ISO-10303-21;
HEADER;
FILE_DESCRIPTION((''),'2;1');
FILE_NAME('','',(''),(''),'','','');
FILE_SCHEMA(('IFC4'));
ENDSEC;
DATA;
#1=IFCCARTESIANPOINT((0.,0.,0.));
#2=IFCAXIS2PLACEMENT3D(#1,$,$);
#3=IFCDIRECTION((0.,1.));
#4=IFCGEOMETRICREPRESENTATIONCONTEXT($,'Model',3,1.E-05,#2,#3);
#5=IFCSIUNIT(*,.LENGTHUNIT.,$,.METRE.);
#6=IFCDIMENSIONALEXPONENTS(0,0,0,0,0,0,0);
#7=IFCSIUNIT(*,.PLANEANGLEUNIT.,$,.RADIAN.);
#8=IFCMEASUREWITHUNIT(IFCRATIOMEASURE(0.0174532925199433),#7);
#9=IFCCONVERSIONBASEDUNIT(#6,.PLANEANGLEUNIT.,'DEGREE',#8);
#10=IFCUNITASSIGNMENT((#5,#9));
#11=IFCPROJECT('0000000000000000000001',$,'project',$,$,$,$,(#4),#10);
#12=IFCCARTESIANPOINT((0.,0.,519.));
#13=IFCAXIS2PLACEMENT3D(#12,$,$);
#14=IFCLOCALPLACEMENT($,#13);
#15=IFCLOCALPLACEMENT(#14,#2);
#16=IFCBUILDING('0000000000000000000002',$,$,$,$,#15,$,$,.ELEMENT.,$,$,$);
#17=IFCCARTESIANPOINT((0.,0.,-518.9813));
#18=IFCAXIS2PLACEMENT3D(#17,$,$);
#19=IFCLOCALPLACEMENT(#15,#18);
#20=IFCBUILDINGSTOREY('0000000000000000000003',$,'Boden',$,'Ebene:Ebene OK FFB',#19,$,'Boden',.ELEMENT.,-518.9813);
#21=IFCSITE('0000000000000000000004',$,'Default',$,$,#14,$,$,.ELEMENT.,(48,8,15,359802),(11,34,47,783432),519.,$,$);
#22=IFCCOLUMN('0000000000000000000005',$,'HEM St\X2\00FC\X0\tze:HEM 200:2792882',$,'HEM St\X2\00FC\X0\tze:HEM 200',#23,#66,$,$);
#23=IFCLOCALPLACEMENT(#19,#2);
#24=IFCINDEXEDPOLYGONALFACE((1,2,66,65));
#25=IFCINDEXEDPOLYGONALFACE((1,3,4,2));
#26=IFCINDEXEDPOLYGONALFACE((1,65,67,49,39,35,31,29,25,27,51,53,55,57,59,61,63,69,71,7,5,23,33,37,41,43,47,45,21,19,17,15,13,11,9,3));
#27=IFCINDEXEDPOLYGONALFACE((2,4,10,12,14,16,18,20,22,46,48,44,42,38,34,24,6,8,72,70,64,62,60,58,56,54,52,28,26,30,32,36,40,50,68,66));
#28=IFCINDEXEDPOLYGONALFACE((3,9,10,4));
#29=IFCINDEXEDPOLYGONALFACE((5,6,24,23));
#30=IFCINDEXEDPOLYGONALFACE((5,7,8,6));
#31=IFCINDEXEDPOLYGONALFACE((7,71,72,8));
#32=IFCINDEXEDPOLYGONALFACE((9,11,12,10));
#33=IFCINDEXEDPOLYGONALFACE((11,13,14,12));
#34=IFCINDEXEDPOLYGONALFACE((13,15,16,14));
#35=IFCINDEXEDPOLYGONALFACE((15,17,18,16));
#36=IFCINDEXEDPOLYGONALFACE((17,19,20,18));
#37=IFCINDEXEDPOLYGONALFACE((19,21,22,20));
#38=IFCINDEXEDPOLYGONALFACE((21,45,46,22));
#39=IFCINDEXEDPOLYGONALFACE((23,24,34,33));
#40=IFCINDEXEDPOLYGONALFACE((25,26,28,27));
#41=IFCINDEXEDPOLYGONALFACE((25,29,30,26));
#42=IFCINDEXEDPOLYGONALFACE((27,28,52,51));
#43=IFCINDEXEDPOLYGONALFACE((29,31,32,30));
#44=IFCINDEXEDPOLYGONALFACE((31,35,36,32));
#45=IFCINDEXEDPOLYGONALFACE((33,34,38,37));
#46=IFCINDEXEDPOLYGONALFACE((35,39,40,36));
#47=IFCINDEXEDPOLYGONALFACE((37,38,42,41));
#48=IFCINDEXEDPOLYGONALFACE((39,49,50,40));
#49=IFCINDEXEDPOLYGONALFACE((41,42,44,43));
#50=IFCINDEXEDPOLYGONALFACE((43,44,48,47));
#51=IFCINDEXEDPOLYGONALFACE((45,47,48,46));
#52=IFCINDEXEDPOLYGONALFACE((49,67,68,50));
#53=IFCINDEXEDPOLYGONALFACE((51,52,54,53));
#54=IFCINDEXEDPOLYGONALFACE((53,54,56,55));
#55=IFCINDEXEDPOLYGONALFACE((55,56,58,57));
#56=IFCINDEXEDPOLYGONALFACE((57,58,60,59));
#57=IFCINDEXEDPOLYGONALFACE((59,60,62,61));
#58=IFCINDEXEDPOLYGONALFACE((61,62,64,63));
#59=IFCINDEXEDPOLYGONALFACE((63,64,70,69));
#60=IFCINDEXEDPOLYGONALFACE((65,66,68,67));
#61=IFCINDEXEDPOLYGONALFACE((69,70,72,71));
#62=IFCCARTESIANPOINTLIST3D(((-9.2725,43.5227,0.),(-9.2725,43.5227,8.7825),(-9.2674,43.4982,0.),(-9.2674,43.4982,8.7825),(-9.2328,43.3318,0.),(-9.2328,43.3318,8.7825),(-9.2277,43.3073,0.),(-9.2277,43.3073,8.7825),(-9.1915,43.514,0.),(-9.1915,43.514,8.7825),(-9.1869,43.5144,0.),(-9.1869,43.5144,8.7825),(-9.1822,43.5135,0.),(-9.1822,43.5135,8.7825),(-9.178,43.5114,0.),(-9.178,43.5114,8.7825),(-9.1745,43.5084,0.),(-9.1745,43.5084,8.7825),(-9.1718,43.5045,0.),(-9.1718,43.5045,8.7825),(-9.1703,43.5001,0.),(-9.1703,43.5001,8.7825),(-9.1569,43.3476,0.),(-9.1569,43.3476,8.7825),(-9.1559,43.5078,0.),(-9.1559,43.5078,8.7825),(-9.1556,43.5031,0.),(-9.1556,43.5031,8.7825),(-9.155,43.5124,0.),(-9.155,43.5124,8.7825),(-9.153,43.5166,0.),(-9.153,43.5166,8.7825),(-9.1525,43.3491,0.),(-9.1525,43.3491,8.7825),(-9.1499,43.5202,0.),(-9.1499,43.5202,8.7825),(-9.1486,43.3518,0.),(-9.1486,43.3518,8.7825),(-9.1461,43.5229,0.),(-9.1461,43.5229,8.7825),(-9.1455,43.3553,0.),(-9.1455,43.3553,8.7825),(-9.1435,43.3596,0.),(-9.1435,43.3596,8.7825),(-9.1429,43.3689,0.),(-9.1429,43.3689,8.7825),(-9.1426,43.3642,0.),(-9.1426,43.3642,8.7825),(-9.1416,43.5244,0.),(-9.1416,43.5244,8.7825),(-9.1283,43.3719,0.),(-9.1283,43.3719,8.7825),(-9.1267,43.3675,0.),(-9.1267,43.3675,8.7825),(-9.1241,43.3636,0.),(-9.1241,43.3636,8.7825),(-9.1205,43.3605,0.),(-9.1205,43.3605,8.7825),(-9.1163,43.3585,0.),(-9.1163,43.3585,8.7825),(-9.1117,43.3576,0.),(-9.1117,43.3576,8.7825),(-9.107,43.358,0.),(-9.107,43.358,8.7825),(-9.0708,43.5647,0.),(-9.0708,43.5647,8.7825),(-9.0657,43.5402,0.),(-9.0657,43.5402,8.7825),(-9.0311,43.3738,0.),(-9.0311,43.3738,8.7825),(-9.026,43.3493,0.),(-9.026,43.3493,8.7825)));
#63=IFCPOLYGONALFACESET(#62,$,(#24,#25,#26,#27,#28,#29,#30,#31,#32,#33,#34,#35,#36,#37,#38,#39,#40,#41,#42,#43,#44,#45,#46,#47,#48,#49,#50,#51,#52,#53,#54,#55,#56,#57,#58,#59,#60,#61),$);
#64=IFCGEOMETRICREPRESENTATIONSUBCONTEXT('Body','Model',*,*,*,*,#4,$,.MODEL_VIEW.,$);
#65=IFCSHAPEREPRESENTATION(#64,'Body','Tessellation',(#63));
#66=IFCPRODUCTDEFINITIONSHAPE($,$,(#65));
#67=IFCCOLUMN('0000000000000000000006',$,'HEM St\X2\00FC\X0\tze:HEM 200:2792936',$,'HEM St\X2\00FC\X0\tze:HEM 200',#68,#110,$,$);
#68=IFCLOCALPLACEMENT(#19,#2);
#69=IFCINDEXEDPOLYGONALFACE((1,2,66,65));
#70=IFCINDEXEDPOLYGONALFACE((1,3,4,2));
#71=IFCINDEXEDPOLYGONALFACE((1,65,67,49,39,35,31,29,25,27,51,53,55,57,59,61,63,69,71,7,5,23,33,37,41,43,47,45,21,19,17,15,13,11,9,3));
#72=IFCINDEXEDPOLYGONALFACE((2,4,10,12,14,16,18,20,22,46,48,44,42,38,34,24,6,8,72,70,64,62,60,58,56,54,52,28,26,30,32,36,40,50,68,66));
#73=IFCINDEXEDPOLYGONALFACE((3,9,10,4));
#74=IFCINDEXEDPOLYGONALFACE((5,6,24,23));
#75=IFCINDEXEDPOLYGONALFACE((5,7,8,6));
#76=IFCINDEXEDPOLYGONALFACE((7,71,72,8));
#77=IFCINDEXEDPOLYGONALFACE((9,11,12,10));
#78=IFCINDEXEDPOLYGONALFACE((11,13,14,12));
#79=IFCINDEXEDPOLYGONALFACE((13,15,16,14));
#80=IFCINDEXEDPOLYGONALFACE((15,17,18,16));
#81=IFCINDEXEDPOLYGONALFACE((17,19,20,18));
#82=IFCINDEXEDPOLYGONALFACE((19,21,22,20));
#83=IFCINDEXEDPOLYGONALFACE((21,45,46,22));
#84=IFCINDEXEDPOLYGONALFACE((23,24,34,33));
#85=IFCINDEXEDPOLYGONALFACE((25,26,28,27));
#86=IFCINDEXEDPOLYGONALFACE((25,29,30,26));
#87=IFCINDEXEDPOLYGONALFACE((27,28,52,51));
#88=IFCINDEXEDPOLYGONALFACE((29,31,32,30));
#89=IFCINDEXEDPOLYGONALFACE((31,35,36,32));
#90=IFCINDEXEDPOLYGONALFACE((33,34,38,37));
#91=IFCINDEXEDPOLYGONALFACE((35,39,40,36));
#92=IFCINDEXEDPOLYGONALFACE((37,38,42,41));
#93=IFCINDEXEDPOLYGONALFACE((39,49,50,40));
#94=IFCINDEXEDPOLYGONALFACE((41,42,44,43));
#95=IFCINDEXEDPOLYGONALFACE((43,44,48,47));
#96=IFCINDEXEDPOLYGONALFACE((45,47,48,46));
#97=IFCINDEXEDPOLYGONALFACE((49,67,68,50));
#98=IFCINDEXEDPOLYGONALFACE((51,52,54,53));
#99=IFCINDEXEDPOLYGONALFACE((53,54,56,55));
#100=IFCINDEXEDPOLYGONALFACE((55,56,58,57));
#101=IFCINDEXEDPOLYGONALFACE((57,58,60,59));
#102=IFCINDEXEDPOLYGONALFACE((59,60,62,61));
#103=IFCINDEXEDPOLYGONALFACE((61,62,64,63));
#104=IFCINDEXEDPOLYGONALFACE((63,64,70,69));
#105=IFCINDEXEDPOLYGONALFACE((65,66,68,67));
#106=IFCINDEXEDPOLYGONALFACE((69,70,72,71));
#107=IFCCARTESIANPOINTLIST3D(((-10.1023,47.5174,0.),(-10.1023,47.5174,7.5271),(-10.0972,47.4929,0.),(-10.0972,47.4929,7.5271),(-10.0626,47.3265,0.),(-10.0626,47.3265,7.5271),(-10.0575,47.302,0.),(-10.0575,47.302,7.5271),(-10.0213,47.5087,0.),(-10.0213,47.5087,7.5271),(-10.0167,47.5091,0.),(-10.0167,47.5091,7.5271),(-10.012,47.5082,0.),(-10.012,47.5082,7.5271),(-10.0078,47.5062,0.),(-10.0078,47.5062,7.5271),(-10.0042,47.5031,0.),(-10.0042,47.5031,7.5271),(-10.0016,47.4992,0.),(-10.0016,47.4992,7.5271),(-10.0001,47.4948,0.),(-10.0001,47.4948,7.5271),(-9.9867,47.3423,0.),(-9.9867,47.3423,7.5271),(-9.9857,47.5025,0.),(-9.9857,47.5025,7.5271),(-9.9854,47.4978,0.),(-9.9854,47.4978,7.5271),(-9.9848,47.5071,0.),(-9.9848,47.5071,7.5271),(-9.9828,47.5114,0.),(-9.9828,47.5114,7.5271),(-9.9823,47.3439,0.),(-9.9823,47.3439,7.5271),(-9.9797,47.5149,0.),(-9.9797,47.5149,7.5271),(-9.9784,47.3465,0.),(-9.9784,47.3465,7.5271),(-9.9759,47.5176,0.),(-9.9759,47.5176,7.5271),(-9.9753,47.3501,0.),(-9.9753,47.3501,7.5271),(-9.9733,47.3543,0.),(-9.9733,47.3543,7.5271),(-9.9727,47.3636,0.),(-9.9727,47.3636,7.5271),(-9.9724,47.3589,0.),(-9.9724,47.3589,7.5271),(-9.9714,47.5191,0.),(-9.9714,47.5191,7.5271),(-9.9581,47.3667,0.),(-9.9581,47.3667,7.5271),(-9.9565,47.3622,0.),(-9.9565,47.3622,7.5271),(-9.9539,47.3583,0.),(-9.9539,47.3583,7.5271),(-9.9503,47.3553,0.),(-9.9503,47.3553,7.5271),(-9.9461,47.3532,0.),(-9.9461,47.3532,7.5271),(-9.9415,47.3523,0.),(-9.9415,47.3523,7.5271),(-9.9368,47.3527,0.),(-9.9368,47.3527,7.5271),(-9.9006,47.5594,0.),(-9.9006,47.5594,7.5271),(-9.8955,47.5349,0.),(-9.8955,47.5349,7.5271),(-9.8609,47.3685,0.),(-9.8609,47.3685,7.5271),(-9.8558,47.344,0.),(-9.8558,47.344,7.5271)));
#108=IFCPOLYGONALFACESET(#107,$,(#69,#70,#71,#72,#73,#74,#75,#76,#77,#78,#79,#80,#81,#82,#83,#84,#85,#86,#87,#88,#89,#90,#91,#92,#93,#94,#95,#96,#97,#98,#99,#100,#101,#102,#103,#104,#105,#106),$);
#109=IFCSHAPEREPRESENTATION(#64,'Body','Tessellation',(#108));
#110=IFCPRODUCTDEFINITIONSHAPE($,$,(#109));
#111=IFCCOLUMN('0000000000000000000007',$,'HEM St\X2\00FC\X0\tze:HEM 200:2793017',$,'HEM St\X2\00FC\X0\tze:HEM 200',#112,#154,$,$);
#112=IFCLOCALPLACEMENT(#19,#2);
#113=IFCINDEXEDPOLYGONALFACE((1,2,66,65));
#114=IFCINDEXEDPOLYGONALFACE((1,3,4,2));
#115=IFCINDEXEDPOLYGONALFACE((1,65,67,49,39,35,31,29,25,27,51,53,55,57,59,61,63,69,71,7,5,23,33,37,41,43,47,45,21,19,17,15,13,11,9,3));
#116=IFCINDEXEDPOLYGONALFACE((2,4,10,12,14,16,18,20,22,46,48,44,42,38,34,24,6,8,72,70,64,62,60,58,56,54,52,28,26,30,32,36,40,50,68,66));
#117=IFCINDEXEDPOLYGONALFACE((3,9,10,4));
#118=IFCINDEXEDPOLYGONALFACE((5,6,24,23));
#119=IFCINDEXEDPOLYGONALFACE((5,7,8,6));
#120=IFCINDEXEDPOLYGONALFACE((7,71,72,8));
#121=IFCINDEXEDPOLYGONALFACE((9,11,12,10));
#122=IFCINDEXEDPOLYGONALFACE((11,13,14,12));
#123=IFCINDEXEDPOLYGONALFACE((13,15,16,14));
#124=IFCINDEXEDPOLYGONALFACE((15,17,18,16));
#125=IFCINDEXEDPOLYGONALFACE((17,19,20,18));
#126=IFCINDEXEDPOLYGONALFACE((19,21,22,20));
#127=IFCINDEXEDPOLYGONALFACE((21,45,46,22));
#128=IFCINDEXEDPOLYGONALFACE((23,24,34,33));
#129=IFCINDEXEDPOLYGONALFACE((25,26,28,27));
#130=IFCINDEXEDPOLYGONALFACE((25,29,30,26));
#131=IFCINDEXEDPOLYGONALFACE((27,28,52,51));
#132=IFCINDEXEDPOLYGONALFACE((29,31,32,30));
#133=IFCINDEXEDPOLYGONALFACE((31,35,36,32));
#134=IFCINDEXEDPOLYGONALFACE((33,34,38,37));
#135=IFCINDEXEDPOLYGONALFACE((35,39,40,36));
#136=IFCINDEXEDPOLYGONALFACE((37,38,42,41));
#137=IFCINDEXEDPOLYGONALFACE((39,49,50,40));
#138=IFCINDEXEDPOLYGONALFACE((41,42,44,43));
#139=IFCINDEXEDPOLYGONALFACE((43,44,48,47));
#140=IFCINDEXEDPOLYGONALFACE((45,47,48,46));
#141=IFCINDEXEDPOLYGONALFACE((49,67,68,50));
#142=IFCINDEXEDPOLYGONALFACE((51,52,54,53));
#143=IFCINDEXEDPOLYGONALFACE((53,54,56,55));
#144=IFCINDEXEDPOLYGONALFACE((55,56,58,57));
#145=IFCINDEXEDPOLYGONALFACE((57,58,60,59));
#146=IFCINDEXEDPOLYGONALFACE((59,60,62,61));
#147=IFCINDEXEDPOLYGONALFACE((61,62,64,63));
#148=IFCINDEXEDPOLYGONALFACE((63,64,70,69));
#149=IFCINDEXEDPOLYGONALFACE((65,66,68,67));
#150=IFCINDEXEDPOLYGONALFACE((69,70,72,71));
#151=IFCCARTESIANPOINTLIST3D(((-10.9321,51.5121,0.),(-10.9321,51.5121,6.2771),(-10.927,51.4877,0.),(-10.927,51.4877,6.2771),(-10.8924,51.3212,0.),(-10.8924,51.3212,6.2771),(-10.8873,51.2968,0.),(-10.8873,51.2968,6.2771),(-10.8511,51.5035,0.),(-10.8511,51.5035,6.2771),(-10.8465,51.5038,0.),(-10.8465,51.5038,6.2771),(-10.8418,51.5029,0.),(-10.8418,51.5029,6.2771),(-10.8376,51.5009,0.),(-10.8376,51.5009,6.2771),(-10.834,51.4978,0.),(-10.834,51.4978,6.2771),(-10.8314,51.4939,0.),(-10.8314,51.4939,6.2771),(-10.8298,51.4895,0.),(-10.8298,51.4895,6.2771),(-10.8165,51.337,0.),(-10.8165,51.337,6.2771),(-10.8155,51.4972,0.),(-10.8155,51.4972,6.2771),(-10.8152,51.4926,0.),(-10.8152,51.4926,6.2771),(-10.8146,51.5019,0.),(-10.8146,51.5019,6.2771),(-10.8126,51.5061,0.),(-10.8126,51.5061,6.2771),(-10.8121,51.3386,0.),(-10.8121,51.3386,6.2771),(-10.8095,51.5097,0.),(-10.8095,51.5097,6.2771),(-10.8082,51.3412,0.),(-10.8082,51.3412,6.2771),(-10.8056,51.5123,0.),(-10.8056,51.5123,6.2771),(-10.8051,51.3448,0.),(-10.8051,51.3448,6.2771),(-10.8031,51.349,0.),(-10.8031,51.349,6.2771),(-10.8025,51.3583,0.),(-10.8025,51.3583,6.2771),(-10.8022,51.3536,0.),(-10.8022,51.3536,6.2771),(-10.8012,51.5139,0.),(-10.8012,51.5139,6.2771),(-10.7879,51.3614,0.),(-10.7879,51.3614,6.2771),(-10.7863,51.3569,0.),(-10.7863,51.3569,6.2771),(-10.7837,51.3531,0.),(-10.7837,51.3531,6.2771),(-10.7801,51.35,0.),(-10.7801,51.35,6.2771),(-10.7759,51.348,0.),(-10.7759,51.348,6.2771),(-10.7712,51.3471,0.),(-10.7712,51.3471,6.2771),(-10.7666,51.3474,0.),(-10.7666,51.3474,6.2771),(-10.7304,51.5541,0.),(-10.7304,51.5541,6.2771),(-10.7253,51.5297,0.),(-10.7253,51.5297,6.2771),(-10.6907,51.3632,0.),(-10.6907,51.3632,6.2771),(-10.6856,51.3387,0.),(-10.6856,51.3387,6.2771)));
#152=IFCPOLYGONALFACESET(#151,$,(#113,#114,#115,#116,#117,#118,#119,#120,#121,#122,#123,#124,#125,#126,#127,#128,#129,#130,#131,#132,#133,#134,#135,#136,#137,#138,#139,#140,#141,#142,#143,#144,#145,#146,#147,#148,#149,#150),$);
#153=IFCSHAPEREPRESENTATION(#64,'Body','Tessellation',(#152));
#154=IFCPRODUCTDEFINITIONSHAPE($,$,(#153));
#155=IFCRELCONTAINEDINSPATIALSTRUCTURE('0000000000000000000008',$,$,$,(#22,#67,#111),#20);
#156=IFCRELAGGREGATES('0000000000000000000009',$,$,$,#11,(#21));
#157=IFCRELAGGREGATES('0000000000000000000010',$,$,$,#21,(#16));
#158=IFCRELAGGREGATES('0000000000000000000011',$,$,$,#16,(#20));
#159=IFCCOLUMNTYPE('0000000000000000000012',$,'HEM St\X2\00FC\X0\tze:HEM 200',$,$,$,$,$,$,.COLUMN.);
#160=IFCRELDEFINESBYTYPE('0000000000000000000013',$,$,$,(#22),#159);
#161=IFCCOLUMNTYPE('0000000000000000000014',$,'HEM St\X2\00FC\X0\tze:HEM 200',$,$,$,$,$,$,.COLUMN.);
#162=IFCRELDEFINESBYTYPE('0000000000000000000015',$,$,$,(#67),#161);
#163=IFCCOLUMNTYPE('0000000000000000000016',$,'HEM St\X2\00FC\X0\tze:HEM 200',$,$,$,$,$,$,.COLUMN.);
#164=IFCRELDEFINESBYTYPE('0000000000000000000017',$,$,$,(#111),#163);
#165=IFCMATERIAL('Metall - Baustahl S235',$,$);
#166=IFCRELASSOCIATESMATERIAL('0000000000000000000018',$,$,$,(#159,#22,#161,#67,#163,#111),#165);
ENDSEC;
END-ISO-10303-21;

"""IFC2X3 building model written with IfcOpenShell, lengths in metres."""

from ifc_helpers import new_model, entity, si_unit, converted_unit, direction, frame, frame_2d, origin, place, context, subcontext, project, spatial, polyline, circle_curve, parameter, trimmed, segment, composite_curve, outline, extrude, source, transform, mapped, material, type_object, type_shapes, element, save


model = new_model("IFC2X3")

# Units and contexts
model_context = context("Model", 3, precision=1e-05, world=origin(), true_north=direction((0.0, 1.0)))
body_context = subcontext(model_context, "Body", "Model", "MODEL_VIEW")
ifc_project = project(units=[si_unit("LENGTHUNIT", "METRE"), converted_unit("PLANEANGLEUNIT", "DEGREE", entity("IfcRatioMeasure", 0.0174532925199433), si_unit("PLANEANGLEUNIT", "RADIAN"), dimensions=[0, 0, 0, 0, 0, 0, 0])], contexts=[model_context])

# Site, building, storey
site_placement = place(None, frame((0.0, 0.0, 519.0)))
site = spatial("IfcSite", under=ifc_project, at=site_placement, Name="Default", CompositionType="ELEMENT", RefLatitude=(48, 8, 15, 359802), RefLongitude=(11, 34, 47, 783432), RefElevation=519.0)
building_placement = place(site_placement, origin())
building = spatial("IfcBuilding", under=site, at=building_placement, CompositionType="ELEMENT")
storey_placement = place(building_placement, frame((0.0, 0.0, -518.9813)))
storey = spatial("IfcBuildingStorey", under=building, at=storey_placement, Name="Boden", ObjectType="Ebene:Ebene OK FFB", LongName="Boden", CompositionType="ELEMENT", Elevation=-518.9813)

# Columns
ifc_material = material(Name="Metall - Baustahl S235")
column_type_1 = type_object("IfcColumnType", Name="HEM Stütze:HEM 200", PredefinedType="COLUMN", material=ifc_material)
shared_shape_1 = source(origin(), body_context, "Body", "SweptSolid", [
    extrude(outline(composite_curve([segment(polyline([(0.085, -0.103), (0.11, -0.103)]), True, "CONTINUOUS"), segment(polyline([(0.11, -0.103), (0.11, 0.103)]), True, "CONTINUOUS"), segment(polyline([(0.11, 0.103), (0.085, 0.103)]), True, "CONTINUOUS"), segment(polyline([(0.085, 0.103), (0.085, 0.0255)]), True, "CONTINUOUS"), segment(trimmed(circle_curve(frame_2d((0.067, 0.0255), x_axis=(1.0, 0.0)), 0.018), [parameter(270.0)], [parameter(0.0)], True, "PARAMETER"), False, "CONTINUOUS"), segment(polyline([(0.067, 0.0075), (-0.067, 0.0075)]), True, "CONTINUOUS"), segment(trimmed(circle_curve(frame_2d((-0.067, 0.0255), x_axis=(0.0, -1.0)), 0.018), [parameter(270.0)], [parameter(0.0)], True, "PARAMETER"), False, "CONTINUOUS"), segment(polyline([(-0.085, 0.0255), (-0.085, 0.103)]), True, "CONTINUOUS"), segment(polyline([(-0.085, 0.103), (-0.11, 0.103)]), True, "CONTINUOUS"), segment(polyline([(-0.11, 0.103), (-0.11, -0.103)]), True, "CONTINUOUS"), segment(polyline([(-0.11, -0.103), (-0.085, -0.103)]), True, "CONTINUOUS"), segment(polyline([(-0.085, -0.103), (-0.085, -0.0255)]), True, "CONTINUOUS"), segment(trimmed(circle_curve(frame_2d((-0.067, -0.0255), x_axis=(-1.0, 0.0)), 0.018), [parameter(270.0)], [parameter(0.0)], True, "PARAMETER"), False, "CONTINUOUS"), segment(polyline([(-0.067, -0.0075), (0.067, -0.0075)]), True, "CONTINUOUS"), segment(trimmed(circle_curve(frame_2d((0.067, -0.0255), x_axis=(0.0, 1.0)), 0.018), [parameter(270.0)], [parameter(0.0)], True, "PARAMETER"), False, "CONTINUOUS"), segment(polyline([(0.085, -0.0255), (0.085, -0.103)]), True, "CONTINUOUS")], self_intersect=False)), frame((-9.1493, 43.436, -518.9813), z_axis=(0.0, 0.0, 1.0), x_axis=(-0.20382, 0.979008, 0.0)), (0.0, 0.0, 1.0), 8.7825),
])
type_shapes(column_type_1, [shared_shape_1])
column_1_placement = place(storey_placement, frame((0.0, 0.0, 518.9813)))
element("IfcColumn", 1, at=column_1_placement, inside=storey, type_object=column_type_1, material=ifc_material, Name="HEM Stütze:HEM 200:2792882", ObjectType="HEM Stütze:HEM 200", context=body_context, shape_type="MappedRepresentation", body=[
    mapped(shared_shape_1, transform((0.0, 0.0, 0.0), scale=1.0)),
])
column_type_2 = type_object("IfcColumnType", Name="HEM Stütze:HEM 200", PredefinedType="COLUMN", material=ifc_material)
shared_shape_2 = source(origin(), body_context, "Body", "SweptSolid", [
    extrude(outline(composite_curve([segment(polyline([(0.085, -0.103), (0.11, -0.103)]), True, "CONTINUOUS"), segment(polyline([(0.11, -0.103), (0.11, 0.103)]), True, "CONTINUOUS"), segment(polyline([(0.11, 0.103), (0.085, 0.103)]), True, "CONTINUOUS"), segment(polyline([(0.085, 0.103), (0.085, 0.0255)]), True, "CONTINUOUS"), segment(trimmed(circle_curve(frame_2d((0.067, 0.0255), x_axis=(1.0, 0.0)), 0.018), [parameter(270.0)], [parameter(0.0)], True, "PARAMETER"), False, "CONTINUOUS"), segment(polyline([(0.067, 0.0075), (-0.067, 0.0075)]), True, "CONTINUOUS"), segment(trimmed(circle_curve(frame_2d((-0.067, 0.0255), x_axis=(0.0, -1.0)), 0.018), [parameter(270.0)], [parameter(0.0)], True, "PARAMETER"), False, "CONTINUOUS"), segment(polyline([(-0.085, 0.0255), (-0.085, 0.103)]), True, "CONTINUOUS"), segment(polyline([(-0.085, 0.103), (-0.11, 0.103)]), True, "CONTINUOUS"), segment(polyline([(-0.11, 0.103), (-0.11, -0.103)]), True, "CONTINUOUS"), segment(polyline([(-0.11, -0.103), (-0.085, -0.103)]), True, "CONTINUOUS"), segment(polyline([(-0.085, -0.103), (-0.085, -0.0255)]), True, "CONTINUOUS"), segment(trimmed(circle_curve(frame_2d((-0.067, -0.0255), x_axis=(-1.0, 0.0)), 0.018), [parameter(270.0)], [parameter(0.0)], True, "PARAMETER"), False, "CONTINUOUS"), segment(polyline([(-0.067, -0.0075), (0.067, -0.0075)]), True, "CONTINUOUS"), segment(trimmed(circle_curve(frame_2d((0.067, -0.0255), x_axis=(0.0, 1.0)), 0.018), [parameter(270.0)], [parameter(0.0)], True, "PARAMETER"), False, "CONTINUOUS"), segment(polyline([(0.085, -0.0255), (0.085, -0.103)]), True, "CONTINUOUS")], self_intersect=False)), frame((-9.9791, 47.4307, -518.9813), z_axis=(0.0, 0.0, 1.0), x_axis=(-0.20382, 0.979008, 0.0)), (0.0, 0.0, 1.0), 7.5271),
])
type_shapes(column_type_2, [shared_shape_2])
column_2_placement = place(storey_placement, frame((0.0, 0.0, 518.9813)))
element("IfcColumn", 2, at=column_2_placement, inside=storey, type_object=column_type_2, material=ifc_material, Name="HEM Stütze:HEM 200:2792936", ObjectType="HEM Stütze:HEM 200", context=body_context, shape_type="MappedRepresentation", body=[
    mapped(shared_shape_2, transform((0.0, 0.0, 0.0), scale=1.0)),
])
column_type_3 = type_object("IfcColumnType", Name="HEM Stütze:HEM 200", PredefinedType="COLUMN", material=ifc_material)
shared_shape_3 = source(origin(), body_context, "Body", "SweptSolid", [
    extrude(outline(composite_curve([segment(polyline([(0.085, -0.103), (0.11, -0.103)]), True, "CONTINUOUS"), segment(polyline([(0.11, -0.103), (0.11, 0.103)]), True, "CONTINUOUS"), segment(polyline([(0.11, 0.103), (0.085, 0.103)]), True, "CONTINUOUS"), segment(polyline([(0.085, 0.103), (0.085, 0.0255)]), True, "CONTINUOUS"), segment(trimmed(circle_curve(frame_2d((0.067, 0.0255), x_axis=(1.0, 0.0)), 0.018), [parameter(270.0)], [parameter(0.0)], True, "PARAMETER"), False, "CONTINUOUS"), segment(polyline([(0.067, 0.0075), (-0.067, 0.0075)]), True, "CONTINUOUS"), segment(trimmed(circle_curve(frame_2d((-0.067, 0.0255), x_axis=(0.0, -1.0)), 0.018), [parameter(270.0)], [parameter(0.0)], True, "PARAMETER"), False, "CONTINUOUS"), segment(polyline([(-0.085, 0.0255), (-0.085, 0.103)]), True, "CONTINUOUS"), segment(polyline([(-0.085, 0.103), (-0.11, 0.103)]), True, "CONTINUOUS"), segment(polyline([(-0.11, 0.103), (-0.11, -0.103)]), True, "CONTINUOUS"), segment(polyline([(-0.11, -0.103), (-0.085, -0.103)]), True, "CONTINUOUS"), segment(polyline([(-0.085, -0.103), (-0.085, -0.0255)]), True, "CONTINUOUS"), segment(trimmed(circle_curve(frame_2d((-0.067, -0.0255), x_axis=(-1.0, 0.0)), 0.018), [parameter(270.0)], [parameter(0.0)], True, "PARAMETER"), False, "CONTINUOUS"), segment(polyline([(-0.067, -0.0075), (0.067, -0.0075)]), True, "CONTINUOUS"), segment(trimmed(circle_curve(frame_2d((0.067, -0.0255), x_axis=(0.0, 1.0)), 0.018), [parameter(270.0)], [parameter(0.0)], True, "PARAMETER"), False, "CONTINUOUS"), segment(polyline([(0.085, -0.0255), (0.085, -0.103)]), True, "CONTINUOUS")], self_intersect=False)), frame((-10.8089, 51.4254, -518.9813), z_axis=(0.0, 0.0, 1.0), x_axis=(-0.20382, 0.979008, 0.0)), (0.0, 0.0, 1.0), 6.2771),
])
type_shapes(column_type_3, [shared_shape_3])
column_3_placement = place(storey_placement, frame((0.0, 0.0, 518.9813)))
element("IfcColumn", 3, at=column_3_placement, inside=storey, type_object=column_type_3, material=ifc_material, Name="HEM Stütze:HEM 200:2793017", ObjectType="HEM Stütze:HEM 200", context=body_context, shape_type="MappedRepresentation", body=[
    mapped(shared_shape_3, transform((0.0, 0.0, 0.0), scale=1.0)),
])

save(model, "model.ifc")
